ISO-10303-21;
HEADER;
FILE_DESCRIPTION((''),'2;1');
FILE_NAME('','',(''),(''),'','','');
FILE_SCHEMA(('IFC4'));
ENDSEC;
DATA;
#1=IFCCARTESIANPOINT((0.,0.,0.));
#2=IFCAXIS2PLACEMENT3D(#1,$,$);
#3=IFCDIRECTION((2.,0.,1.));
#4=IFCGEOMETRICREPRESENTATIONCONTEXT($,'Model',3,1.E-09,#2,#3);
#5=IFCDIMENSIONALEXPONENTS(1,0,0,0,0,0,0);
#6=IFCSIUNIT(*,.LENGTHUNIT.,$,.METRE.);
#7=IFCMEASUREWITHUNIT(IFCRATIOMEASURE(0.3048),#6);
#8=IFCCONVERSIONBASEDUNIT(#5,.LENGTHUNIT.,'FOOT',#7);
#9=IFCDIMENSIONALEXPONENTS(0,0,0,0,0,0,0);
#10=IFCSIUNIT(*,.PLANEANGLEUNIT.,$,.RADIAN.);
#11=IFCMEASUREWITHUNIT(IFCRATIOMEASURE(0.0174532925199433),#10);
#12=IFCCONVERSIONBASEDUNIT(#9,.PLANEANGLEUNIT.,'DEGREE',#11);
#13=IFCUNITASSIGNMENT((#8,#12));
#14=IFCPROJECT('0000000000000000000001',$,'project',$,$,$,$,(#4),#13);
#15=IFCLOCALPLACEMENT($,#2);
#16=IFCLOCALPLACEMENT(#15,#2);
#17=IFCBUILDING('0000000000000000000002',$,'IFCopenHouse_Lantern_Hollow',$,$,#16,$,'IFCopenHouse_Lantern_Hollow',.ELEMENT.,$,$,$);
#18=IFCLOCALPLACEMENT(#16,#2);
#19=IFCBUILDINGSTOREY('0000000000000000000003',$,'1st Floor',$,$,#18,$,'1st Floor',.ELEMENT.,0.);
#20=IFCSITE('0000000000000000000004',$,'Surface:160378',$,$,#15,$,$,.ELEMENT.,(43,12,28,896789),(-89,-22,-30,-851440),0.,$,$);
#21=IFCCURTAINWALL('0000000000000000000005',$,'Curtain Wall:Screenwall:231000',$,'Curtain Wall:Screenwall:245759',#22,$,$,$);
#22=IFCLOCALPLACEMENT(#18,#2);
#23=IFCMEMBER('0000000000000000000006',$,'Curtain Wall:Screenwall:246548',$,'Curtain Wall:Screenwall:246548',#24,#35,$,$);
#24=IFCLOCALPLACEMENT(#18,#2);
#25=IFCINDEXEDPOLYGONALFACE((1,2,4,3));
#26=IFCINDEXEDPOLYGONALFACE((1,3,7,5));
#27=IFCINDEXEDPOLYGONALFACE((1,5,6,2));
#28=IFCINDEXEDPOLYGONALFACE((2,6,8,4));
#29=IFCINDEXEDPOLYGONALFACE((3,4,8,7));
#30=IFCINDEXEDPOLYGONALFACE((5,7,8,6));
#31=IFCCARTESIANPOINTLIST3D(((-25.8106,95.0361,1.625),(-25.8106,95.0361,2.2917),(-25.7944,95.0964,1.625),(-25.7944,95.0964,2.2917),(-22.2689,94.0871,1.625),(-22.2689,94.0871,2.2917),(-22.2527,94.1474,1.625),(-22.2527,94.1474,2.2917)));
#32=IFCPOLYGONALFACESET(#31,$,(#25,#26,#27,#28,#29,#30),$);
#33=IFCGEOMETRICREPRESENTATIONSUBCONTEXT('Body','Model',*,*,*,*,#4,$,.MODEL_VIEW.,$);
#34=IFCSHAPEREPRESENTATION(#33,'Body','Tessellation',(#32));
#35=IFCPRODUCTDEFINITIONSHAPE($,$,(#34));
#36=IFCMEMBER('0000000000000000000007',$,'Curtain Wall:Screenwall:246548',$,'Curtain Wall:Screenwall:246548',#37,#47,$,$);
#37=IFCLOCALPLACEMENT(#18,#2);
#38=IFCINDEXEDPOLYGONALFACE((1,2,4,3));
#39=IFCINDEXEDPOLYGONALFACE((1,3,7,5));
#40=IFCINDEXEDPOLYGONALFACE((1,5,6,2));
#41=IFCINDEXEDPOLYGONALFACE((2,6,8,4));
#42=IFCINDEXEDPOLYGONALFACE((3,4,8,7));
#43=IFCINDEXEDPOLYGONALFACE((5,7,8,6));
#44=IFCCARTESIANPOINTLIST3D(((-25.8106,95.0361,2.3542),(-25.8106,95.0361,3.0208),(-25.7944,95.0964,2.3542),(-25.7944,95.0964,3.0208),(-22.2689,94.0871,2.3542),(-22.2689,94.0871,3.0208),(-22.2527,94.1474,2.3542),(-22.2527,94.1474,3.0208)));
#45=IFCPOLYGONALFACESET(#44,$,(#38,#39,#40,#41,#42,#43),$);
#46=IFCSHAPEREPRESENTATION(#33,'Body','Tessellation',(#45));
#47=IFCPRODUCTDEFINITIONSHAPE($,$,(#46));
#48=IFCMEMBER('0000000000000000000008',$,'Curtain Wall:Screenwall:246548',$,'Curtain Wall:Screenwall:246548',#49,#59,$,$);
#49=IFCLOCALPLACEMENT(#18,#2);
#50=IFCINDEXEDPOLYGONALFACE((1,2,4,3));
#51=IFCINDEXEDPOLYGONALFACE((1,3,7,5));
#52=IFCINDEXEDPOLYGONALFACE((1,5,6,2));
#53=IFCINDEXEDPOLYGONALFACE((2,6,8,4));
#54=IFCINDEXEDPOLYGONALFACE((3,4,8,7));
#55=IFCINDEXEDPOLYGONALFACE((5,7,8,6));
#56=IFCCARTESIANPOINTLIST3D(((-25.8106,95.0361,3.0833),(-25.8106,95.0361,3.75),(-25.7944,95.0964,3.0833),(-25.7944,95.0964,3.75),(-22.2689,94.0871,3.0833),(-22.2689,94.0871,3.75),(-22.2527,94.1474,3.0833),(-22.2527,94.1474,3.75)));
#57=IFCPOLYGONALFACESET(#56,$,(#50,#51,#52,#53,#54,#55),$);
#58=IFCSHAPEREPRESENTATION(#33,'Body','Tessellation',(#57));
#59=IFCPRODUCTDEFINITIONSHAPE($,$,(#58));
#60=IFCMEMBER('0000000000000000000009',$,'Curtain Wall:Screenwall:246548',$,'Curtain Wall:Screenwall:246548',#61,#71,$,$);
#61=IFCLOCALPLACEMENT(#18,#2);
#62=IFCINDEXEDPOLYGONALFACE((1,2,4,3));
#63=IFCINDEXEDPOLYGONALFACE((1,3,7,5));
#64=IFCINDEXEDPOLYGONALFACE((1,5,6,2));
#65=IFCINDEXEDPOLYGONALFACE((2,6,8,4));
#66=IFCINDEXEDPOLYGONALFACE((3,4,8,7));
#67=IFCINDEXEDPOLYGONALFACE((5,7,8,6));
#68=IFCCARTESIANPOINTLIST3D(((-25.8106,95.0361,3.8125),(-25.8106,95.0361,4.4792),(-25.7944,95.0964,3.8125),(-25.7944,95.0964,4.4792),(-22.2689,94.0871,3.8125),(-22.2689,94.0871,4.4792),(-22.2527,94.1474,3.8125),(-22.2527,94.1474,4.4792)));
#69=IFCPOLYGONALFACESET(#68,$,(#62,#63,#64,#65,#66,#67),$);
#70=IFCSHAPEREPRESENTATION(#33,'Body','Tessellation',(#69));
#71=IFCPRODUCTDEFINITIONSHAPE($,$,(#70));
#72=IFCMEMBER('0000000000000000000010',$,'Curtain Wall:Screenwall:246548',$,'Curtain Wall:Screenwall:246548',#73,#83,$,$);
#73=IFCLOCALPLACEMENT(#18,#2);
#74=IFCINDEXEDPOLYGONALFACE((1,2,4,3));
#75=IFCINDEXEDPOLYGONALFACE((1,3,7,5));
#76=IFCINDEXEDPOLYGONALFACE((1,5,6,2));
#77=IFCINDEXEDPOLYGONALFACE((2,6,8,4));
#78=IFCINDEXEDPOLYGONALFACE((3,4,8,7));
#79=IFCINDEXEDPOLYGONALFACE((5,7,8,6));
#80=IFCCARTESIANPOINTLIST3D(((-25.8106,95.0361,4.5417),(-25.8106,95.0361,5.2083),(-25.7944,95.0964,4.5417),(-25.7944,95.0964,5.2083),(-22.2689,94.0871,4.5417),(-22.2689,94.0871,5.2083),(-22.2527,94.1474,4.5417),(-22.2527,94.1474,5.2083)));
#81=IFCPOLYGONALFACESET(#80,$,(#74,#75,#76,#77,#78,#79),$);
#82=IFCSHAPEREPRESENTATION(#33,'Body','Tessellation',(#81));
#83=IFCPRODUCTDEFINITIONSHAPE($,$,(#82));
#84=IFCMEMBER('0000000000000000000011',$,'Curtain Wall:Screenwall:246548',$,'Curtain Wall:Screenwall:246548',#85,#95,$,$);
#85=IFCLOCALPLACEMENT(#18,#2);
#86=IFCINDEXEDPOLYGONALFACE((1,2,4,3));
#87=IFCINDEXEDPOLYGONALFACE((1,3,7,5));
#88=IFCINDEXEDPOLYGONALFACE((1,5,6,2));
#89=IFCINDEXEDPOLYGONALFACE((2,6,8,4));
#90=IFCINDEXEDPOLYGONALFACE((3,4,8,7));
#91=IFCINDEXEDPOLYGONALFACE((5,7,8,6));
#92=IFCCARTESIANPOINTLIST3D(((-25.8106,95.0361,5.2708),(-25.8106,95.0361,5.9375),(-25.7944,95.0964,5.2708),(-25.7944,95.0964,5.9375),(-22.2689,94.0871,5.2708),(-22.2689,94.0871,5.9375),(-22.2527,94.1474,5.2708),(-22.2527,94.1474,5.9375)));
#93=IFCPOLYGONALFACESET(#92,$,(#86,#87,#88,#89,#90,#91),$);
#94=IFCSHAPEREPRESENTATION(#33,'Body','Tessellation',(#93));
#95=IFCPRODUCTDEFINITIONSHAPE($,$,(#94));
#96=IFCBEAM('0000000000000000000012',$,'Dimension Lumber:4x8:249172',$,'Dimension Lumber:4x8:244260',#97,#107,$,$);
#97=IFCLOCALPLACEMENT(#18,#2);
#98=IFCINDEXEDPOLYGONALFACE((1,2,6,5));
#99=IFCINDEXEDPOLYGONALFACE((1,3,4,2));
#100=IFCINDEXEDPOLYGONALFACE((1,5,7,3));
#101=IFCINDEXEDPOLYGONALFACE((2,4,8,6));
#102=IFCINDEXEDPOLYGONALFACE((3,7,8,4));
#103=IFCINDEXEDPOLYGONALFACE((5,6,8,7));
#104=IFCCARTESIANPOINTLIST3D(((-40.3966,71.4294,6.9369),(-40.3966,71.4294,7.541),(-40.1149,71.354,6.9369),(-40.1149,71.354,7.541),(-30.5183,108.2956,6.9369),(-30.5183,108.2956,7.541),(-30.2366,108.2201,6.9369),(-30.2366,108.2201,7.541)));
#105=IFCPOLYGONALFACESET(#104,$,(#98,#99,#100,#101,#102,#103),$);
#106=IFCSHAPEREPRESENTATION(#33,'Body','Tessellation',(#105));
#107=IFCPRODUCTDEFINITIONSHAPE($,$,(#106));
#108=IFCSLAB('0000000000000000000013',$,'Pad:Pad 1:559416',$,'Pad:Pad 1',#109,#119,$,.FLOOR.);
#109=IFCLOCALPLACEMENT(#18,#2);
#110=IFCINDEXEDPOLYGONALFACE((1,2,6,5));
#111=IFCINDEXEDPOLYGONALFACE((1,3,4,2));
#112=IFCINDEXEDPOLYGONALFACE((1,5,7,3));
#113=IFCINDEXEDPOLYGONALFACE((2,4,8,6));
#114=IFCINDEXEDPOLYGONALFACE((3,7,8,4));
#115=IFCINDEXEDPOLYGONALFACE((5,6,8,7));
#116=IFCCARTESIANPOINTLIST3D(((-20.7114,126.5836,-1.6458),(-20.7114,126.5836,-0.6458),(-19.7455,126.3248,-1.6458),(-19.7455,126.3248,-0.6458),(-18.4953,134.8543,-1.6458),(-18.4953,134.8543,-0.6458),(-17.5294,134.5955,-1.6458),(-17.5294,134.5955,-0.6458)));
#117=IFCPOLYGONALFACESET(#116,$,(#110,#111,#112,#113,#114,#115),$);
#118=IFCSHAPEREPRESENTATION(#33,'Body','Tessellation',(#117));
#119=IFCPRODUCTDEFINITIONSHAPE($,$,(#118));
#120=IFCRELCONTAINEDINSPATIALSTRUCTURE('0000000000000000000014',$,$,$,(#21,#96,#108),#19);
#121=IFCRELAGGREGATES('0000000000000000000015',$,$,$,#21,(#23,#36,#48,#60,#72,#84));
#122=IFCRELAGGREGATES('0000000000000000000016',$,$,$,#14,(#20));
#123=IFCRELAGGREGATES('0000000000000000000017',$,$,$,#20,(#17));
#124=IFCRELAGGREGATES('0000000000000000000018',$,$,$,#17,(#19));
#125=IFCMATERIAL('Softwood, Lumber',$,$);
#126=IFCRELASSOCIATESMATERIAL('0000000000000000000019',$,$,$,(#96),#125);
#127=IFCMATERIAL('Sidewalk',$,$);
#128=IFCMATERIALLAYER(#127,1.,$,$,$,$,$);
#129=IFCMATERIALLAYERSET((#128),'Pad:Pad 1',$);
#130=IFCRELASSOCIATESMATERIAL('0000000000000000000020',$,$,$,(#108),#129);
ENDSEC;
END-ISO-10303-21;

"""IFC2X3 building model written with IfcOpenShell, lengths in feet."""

from ifc_helpers import new_model, entity, si_unit, converted_unit, direction, frame, frame_2d, origin, origin_2d_with_axis, place, context, subcontext, project, spatial, rectangle, extrude, material, layer, layer_set, layer_usage, element, aggregate, save


model = new_model("IFC2X3")

# Units and contexts
model_context = context("Model", 3, precision=1e-09, world=origin(), true_north=direction((2.0, 0.0, 1.0)))
body_context = subcontext(model_context, "Body", "Model", "MODEL_VIEW")
ifc_project = project(units=[converted_unit("LENGTHUNIT", "FOOT", entity("IfcRatioMeasure", 0.3048), si_unit("LENGTHUNIT", "METRE"), dimensions=[1, 0, 0, 0, 0, 0, 0]), converted_unit("PLANEANGLEUNIT", "DEGREE", entity("IfcRatioMeasure", 0.0174532925199433), si_unit("PLANEANGLEUNIT", "RADIAN"), dimensions=[0, 0, 0, 0, 0, 0, 0])], contexts=[model_context])

# Site, building, storey
site_placement = place(None, origin())
site = spatial("IfcSite", under=ifc_project, at=site_placement, Name="Surface:160378", CompositionType="ELEMENT", RefLatitude=(43, 12, 28, 896789), RefLongitude=(-89, -22, -30, -851440), RefElevation=0.0)
building_placement = place(site_placement, origin())
building = spatial("IfcBuilding", under=site, at=building_placement, Name="IFCopenHouse_Lantern_Hollow", LongName="IFCopenHouse_Lantern_Hollow", CompositionType="ELEMENT")
storey_placement = place(building_placement, origin())
storey = spatial("IfcBuildingStorey", under=building, at=storey_placement, Name="1st Floor", LongName="1st Floor", CompositionType="ELEMENT", Elevation=0.0)

# Curtain wall, members
curtain_wall_placement = place(storey_placement, origin())
curtain_wall = element("IfcCurtainWall", 1, at=curtain_wall_placement, inside=storey, Name="Curtain Wall:Screenwall:231000", ObjectType="Curtain Wall:Screenwall:245759")
member_1_placement = place(curtain_wall_placement, frame((-25.8106, 94.0871, 1.625)))
member_1 = element("IfcMember", 2, at=member_1_placement, Name="Curtain Wall:Screenwall:246548", ObjectType="Curtain Wall:Screenwall:246548", context=body_context, shape_type="SweptSolid", body=[
    extrude(rectangle(XDim=3.6667, YDim=0.0625, at=origin_2d_with_axis()), frame((1.779, 0.5047, 0.0), z_axis=(0.0, 0.0, 1.0), x_axis=(-0.965926, 0.258819, 0.0)), (0.0, 0.0, 1.0), 0.6667),
])
member_2_placement = place(curtain_wall_placement, frame((-25.8106, 94.0871, 2.3542)))
member_2 = element("IfcMember", 3, at=member_2_placement, Name="Curtain Wall:Screenwall:246548", ObjectType="Curtain Wall:Screenwall:246548", context=body_context, shape_type="SweptSolid", body=[
    extrude(rectangle(XDim=3.6667, YDim=0.0625, at=origin_2d_with_axis()), frame((1.779, 0.5047, 0.0), z_axis=(0.0, 0.0, 1.0), x_axis=(-0.965926, 0.258819, 0.0)), (0.0, 0.0, 1.0), 0.6667),
])
member_3_placement = place(curtain_wall_placement, frame((-25.8106, 94.0871, 3.0833)))
member_3 = element("IfcMember", 4, at=member_3_placement, Name="Curtain Wall:Screenwall:246548", ObjectType="Curtain Wall:Screenwall:246548", context=body_context, shape_type="SweptSolid", body=[
    extrude(rectangle(XDim=3.6667, YDim=0.0625, at=origin_2d_with_axis()), frame((1.779, 0.5047, 0.0), z_axis=(0.0, 0.0, 1.0), x_axis=(-0.965926, 0.258819, 0.0)), (0.0, 0.0, 1.0), 0.6667),
])
member_4_placement = place(curtain_wall_placement, frame((-25.8106, 94.0871, 3.8125)))
member_4 = element("IfcMember", 5, at=member_4_placement, Name="Curtain Wall:Screenwall:246548", ObjectType="Curtain Wall:Screenwall:246548", context=body_context, shape_type="SweptSolid", body=[
    extrude(rectangle(XDim=3.6667, YDim=0.0625, at=origin_2d_with_axis()), frame((1.779, 0.5047, 0.0), z_axis=(0.0, 0.0, 1.0), x_axis=(-0.965926, 0.258819, 0.0)), (0.0, 0.0, 1.0), 0.6667),
])
member_5_placement = place(curtain_wall_placement, frame((-25.8106, 94.0871, 4.5417)))
member_5 = element("IfcMember", 6, at=member_5_placement, Name="Curtain Wall:Screenwall:246548", ObjectType="Curtain Wall:Screenwall:246548", context=body_context, shape_type="SweptSolid", body=[
    extrude(rectangle(XDim=3.6667, YDim=0.0625, at=origin_2d_with_axis()), frame((1.779, 0.5047, 0.0), z_axis=(0.0, 0.0, 1.0), x_axis=(-0.965926, 0.258819, 0.0)), (0.0, 0.0, 1.0), 0.6667),
])
member_6_placement = place(curtain_wall_placement, frame((-25.8106, 94.0871, 5.2708)))
member_6 = element("IfcMember", 7, at=member_6_placement, Name="Curtain Wall:Screenwall:246548", ObjectType="Curtain Wall:Screenwall:246548", context=body_context, shape_type="SweptSolid", body=[
    extrude(rectangle(XDim=3.6667, YDim=0.0625, at=origin_2d_with_axis()), frame((1.779, 0.5047, 0.0), z_axis=(0.0, 0.0, 1.0), x_axis=(-0.965926, 0.258819, 0.0)), (0.0, 0.0, 1.0), 0.6667),
])
aggregate(curtain_wall, [member_1, member_2, member_3, member_4, member_5, member_6])

# Beam
ifc_material_1 = material(Name="Softwood, Lumber")
beam_1_placement = place(storey_placement, frame((-30.3775, 108.2579, 6.9369), z_axis=(0.0, 0.0, 1.0), x_axis=(-0.258819, -0.965926, 0.0)))
element("IfcBeam", 8, at=beam_1_placement, inside=storey, material=ifc_material_1, Name="Dimension Lumber:4x8:249172", ObjectType="Dimension Lumber:4x8:244260", context=body_context, shape_type="SweptSolid", body=[
    extrude(rectangle(XDim=0.6042, YDim=0.2917, at=frame_2d((0.0, 0.0), x_axis=(1.0, 0.0))), frame((0.0, 0.0, 0.3021), z_axis=(1.0, 0.0, 0.0), x_axis=(0.0, 0.0, -1.0)), (0.0, 0.0, 1.0), 38.1667),
])

# Slab
ifc_material_2 = material(Name="Sidewalk")
ifc_layer = layer(ifc_material_2, 1.0)
ifc_layer_set = layer_set([ifc_layer], Name="Pad:Pad 1")
ifc_layer_usage = layer_usage(ifc_layer_set, "AXIS3", "NEGATIVE", 0.0)
slab_placement = place(storey_placement, frame((-20.7114, 126.3248, -1.6458)))
element("IfcSlab", 9, at=slab_placement, inside=storey, material=ifc_layer_usage, Name="Pad:Pad 1:559416", ObjectType="Pad:Pad 1", PredefinedType="FLOOR", context=body_context, shape_type="SweptSolid", body=[
    extrude(rectangle(XDim=8.5625, YDim=1.0, at=frame_2d((0.0, 0.0), x_axis=(-0.258819, 0.965926))), frame((1.591, 4.2648, 1.0), z_axis=(0.0, 0.0, -1.0), x_axis=(-1.0, 0.0, 0.0)), (0.0, 0.0, 1.0), 1.0),
])

save(model, "model.ifc")
